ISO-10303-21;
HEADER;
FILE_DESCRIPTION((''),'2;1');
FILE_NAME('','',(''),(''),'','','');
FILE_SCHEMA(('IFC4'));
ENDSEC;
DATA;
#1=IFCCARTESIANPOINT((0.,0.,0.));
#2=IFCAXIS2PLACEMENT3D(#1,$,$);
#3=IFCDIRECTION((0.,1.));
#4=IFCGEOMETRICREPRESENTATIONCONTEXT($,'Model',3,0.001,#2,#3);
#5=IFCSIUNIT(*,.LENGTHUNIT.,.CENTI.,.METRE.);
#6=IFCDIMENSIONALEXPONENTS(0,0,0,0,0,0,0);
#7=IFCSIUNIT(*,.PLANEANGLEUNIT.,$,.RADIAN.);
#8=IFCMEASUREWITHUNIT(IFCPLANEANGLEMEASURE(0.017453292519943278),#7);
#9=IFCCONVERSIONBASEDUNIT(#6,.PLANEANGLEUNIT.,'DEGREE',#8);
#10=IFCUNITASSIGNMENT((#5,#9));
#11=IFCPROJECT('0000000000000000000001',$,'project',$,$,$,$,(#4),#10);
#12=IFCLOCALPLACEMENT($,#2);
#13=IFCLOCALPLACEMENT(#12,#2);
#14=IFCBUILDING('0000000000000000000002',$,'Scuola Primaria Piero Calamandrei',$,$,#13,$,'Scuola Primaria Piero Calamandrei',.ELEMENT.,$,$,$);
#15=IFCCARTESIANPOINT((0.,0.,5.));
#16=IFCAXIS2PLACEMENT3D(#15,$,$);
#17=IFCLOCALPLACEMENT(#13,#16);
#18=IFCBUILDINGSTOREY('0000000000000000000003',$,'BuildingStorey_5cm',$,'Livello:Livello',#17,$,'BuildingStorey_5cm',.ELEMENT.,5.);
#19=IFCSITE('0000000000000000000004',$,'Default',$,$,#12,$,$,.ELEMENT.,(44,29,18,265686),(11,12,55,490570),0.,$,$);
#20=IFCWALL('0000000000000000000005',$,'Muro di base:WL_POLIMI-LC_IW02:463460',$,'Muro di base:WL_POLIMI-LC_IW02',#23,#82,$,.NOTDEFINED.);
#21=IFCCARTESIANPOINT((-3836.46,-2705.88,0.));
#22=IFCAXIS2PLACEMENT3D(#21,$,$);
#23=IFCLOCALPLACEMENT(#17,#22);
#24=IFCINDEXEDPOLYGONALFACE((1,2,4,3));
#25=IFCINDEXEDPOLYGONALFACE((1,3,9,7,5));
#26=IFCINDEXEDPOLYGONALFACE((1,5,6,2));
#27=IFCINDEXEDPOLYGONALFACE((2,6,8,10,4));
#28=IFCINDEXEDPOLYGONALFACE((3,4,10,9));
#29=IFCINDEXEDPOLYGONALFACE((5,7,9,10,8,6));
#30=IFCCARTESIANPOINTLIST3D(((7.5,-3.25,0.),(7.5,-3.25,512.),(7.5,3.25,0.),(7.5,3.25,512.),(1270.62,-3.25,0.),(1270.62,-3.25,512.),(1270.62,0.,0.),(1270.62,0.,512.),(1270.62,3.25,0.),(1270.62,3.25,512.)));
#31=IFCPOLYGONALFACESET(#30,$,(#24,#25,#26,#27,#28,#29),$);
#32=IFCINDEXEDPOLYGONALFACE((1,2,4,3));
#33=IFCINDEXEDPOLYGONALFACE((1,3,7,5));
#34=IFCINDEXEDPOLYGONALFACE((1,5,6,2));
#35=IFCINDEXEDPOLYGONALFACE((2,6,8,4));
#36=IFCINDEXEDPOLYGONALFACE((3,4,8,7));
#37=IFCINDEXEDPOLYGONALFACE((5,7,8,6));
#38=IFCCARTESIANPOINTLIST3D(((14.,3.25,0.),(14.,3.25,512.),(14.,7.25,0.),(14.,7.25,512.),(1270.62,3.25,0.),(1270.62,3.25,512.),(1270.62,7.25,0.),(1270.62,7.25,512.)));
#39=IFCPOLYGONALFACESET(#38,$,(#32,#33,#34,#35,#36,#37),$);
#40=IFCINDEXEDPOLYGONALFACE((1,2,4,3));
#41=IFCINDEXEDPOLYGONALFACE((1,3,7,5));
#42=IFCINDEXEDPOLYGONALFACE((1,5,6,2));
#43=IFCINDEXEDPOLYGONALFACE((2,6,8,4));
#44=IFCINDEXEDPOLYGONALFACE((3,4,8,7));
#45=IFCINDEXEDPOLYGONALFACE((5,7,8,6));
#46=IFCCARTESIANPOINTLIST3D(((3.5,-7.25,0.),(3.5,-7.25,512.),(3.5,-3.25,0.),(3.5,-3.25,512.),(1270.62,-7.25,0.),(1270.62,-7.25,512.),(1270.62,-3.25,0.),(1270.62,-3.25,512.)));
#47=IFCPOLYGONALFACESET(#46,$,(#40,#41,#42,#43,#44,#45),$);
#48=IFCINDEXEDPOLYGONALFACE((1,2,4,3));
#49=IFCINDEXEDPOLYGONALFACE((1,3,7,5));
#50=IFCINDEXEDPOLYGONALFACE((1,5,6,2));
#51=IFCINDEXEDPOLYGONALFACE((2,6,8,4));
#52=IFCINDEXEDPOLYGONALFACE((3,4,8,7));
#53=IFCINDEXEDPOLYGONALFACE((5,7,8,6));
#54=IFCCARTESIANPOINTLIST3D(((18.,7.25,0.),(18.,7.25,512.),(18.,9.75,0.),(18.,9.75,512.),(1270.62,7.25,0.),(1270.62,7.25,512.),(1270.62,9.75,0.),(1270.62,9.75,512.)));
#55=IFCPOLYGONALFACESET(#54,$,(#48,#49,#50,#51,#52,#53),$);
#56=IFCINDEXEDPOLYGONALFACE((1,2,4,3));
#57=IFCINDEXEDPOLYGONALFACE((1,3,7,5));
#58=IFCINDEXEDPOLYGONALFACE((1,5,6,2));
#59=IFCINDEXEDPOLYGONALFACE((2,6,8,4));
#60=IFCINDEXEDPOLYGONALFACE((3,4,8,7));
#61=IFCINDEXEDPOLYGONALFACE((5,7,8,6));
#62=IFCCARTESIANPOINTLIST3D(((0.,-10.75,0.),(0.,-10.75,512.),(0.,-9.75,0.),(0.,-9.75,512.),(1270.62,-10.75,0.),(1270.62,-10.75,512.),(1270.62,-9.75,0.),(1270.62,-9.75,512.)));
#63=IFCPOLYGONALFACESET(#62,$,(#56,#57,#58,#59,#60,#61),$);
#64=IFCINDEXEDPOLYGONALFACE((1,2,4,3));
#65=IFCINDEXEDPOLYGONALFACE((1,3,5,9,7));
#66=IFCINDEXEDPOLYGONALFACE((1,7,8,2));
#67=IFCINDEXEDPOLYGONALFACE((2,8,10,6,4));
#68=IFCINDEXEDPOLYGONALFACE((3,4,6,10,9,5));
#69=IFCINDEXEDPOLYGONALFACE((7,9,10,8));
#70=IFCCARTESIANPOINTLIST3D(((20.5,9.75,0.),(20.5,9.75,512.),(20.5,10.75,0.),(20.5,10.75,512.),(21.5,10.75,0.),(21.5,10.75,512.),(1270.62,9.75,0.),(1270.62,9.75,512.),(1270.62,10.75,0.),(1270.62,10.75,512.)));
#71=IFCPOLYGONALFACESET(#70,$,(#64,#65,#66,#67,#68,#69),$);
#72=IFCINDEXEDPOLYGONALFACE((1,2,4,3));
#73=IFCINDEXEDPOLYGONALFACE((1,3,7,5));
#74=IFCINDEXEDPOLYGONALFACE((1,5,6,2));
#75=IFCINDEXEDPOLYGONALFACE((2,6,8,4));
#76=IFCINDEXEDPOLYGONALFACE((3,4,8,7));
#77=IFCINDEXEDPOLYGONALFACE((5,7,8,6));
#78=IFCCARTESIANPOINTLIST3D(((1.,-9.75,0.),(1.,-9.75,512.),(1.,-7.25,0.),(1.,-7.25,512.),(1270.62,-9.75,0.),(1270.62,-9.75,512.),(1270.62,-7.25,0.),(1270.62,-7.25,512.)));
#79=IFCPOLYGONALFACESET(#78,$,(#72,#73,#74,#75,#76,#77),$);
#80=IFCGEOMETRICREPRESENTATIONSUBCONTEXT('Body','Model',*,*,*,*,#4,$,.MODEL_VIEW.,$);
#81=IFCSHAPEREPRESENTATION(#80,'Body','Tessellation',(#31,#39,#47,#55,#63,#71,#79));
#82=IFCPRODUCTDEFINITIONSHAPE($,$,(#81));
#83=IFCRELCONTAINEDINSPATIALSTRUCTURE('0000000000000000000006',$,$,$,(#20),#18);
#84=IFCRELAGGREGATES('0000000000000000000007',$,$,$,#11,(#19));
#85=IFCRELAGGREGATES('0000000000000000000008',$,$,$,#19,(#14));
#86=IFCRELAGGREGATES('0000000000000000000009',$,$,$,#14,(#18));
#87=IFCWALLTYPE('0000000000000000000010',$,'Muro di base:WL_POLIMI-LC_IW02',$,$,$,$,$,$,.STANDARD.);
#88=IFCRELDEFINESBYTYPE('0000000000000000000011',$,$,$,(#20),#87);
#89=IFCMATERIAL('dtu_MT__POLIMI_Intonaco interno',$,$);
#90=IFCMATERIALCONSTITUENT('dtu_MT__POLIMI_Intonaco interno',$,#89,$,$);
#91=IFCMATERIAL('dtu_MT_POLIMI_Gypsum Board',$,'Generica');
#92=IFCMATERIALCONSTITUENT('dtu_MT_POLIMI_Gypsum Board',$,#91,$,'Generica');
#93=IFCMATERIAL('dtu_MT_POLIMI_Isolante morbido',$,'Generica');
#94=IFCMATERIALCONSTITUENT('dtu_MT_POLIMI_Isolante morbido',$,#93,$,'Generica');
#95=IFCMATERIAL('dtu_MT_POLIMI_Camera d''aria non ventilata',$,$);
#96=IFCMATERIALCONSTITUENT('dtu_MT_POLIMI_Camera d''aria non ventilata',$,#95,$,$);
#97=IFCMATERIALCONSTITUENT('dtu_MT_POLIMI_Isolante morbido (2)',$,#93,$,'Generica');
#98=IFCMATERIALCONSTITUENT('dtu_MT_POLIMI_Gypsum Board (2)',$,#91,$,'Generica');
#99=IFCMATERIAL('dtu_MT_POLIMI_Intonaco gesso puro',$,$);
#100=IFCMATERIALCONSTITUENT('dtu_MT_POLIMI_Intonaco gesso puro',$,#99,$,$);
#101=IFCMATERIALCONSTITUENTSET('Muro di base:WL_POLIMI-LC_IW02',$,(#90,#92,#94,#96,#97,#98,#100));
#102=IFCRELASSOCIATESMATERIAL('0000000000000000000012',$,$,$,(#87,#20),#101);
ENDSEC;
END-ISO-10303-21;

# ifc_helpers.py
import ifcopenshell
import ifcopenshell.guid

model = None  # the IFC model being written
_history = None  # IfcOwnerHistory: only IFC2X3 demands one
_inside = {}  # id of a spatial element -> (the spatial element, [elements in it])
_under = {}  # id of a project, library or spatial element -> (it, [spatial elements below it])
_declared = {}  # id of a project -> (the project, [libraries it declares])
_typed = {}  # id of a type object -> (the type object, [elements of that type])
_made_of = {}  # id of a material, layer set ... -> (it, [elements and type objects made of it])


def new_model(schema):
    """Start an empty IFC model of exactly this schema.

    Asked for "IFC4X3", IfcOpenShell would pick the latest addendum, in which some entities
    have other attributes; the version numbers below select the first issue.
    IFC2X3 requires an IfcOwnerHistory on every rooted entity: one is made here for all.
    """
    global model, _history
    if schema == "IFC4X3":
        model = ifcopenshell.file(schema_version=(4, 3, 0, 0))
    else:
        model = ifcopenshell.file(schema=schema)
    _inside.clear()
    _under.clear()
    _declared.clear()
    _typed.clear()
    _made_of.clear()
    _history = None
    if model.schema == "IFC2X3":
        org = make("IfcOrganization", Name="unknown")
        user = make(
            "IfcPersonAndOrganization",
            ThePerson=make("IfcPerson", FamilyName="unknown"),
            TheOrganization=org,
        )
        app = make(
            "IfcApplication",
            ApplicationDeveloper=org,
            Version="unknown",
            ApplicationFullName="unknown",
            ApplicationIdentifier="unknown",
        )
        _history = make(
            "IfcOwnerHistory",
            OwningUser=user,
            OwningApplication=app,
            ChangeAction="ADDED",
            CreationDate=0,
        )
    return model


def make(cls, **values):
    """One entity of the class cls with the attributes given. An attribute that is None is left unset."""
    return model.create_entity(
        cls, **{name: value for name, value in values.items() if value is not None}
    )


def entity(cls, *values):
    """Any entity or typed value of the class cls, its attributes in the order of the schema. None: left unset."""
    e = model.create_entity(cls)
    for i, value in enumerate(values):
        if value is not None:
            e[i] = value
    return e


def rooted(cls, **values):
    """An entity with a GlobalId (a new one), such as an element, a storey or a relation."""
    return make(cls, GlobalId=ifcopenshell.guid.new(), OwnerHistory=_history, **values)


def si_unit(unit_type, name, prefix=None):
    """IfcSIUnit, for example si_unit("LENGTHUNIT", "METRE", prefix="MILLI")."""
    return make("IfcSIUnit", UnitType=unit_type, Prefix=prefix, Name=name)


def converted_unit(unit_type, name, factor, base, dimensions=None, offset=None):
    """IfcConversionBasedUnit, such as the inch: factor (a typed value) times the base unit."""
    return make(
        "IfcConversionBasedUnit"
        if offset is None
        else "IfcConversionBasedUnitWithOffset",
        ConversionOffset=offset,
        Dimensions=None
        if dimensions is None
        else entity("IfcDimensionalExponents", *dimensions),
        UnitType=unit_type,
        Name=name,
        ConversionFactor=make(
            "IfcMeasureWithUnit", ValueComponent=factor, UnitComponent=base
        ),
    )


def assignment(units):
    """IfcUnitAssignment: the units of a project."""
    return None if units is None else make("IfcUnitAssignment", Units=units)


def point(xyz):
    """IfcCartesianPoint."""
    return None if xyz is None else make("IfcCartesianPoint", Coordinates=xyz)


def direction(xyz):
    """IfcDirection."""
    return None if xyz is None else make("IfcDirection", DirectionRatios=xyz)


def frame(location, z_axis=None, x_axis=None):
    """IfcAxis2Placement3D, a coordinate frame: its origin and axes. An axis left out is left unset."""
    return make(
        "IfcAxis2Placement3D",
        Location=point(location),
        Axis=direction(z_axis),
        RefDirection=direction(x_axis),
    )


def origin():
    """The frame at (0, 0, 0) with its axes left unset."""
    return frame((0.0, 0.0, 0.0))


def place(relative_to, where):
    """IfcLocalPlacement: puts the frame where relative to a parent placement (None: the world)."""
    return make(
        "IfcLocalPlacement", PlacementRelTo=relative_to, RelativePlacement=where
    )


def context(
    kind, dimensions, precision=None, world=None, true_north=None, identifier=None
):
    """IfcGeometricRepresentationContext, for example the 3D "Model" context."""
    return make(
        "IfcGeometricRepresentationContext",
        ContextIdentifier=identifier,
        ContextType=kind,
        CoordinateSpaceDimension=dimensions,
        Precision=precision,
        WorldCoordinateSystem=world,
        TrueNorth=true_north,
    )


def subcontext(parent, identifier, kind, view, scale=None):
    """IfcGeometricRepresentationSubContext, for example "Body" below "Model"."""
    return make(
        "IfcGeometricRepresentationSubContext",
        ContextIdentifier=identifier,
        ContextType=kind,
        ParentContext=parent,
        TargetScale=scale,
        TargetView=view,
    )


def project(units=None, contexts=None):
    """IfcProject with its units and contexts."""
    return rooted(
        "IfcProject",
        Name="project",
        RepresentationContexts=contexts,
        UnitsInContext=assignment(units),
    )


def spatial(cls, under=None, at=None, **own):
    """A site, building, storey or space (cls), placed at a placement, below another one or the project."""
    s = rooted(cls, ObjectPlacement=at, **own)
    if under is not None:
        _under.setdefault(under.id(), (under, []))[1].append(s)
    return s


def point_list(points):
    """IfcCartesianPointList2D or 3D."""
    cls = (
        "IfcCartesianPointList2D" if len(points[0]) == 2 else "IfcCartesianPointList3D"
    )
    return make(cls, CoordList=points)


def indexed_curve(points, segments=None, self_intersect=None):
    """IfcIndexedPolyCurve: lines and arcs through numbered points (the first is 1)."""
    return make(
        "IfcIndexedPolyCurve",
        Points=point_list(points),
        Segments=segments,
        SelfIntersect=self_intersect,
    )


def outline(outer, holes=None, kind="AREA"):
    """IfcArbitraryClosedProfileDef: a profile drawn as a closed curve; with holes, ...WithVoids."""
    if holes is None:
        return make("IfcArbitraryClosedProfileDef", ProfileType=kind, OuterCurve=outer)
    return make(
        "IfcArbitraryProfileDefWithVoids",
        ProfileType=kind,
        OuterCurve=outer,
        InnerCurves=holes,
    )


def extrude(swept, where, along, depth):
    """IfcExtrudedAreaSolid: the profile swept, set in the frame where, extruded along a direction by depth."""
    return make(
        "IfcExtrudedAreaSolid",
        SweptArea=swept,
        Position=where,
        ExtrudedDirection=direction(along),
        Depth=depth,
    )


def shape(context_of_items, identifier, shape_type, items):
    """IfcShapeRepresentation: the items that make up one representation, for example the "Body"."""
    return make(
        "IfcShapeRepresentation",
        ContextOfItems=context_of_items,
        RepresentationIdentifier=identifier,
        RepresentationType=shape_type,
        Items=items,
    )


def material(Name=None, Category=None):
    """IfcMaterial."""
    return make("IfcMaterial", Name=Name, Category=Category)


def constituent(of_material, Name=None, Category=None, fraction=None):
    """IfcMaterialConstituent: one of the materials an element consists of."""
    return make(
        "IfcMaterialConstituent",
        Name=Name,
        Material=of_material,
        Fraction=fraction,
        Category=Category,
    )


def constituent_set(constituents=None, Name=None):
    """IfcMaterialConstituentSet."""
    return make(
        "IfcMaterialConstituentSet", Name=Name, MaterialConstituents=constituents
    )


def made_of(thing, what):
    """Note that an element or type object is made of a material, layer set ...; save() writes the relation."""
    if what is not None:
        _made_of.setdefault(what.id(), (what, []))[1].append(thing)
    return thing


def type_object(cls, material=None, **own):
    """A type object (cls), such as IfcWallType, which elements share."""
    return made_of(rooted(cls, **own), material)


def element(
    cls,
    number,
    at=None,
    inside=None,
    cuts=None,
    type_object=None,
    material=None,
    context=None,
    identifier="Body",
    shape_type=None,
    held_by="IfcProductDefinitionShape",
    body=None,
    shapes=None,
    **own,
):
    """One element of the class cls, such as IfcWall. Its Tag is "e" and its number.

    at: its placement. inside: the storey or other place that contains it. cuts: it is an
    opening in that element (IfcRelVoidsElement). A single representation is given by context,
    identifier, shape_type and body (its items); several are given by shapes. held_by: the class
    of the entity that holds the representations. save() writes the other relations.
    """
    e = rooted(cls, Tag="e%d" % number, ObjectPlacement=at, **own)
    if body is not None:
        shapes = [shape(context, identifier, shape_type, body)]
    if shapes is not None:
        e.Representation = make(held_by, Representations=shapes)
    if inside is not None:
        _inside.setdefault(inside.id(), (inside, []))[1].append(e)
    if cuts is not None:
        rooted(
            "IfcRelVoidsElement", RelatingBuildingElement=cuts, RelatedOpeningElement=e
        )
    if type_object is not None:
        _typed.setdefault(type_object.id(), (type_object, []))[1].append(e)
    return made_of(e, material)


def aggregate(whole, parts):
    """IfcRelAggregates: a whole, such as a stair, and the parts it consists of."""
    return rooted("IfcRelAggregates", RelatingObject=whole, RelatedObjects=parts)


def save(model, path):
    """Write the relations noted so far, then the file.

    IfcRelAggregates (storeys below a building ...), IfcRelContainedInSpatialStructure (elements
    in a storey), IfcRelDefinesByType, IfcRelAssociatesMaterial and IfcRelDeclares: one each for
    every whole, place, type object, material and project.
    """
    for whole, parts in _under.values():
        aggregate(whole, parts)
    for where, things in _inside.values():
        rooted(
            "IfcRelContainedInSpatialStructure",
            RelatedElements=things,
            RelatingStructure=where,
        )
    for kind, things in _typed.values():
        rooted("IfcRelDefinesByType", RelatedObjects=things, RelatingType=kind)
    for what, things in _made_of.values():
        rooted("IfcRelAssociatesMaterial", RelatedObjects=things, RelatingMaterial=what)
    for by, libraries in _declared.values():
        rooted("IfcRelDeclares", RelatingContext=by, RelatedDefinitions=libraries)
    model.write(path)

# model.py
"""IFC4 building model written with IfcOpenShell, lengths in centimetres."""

from ifc_helpers import new_model, entity, si_unit, converted_unit, direction, frame, origin, place, context, subcontext, project, spatial, indexed_curve, outline, extrude, material, constituent, constituent_set, type_object, element, save


model = new_model("IFC4")

# Units and contexts
model_context = context("Model", 3, precision=0.001, world=origin(), true_north=direction((0.0, 1.0)))
body_context = subcontext(model_context, "Body", "Model", "MODEL_VIEW")
ifc_project = project(units=[si_unit("LENGTHUNIT", "METRE", prefix="CENTI"), converted_unit("PLANEANGLEUNIT", "DEGREE", entity("IfcPlaneAngleMeasure", 0.017453292519943278), si_unit("PLANEANGLEUNIT", "RADIAN"), dimensions=[0, 0, 0, 0, 0, 0, 0])], contexts=[model_context])

# Site, building, storey
site_placement = place(None, origin())
site = spatial("IfcSite", under=ifc_project, at=site_placement, Name="Default", CompositionType="ELEMENT", RefLatitude=(44, 29, 18, 265686), RefLongitude=(11, 12, 55, 490570), RefElevation=0.0)
building_placement = place(site_placement, origin())
building = spatial("IfcBuilding", under=site, at=building_placement, Name="Scuola Primaria Piero Calamandrei", LongName="Scuola Primaria Piero Calamandrei", CompositionType="ELEMENT")
storey_placement = place(building_placement, frame((0.0, 0.0, 5.0)))
storey = spatial("IfcBuildingStorey", under=building, at=storey_placement, Name="BuildingStorey_5cm", ObjectType="Livello:Livello", LongName="BuildingStorey_5cm", CompositionType="ELEMENT", Elevation=5.0)

# Shared definitions
ifc_material_1 = material(Name="dtu_MT_POLIMI_Intonaco gesso puro")

# Wall
ifc_material_2 = material(Name="dtu_MT_POLIMI_Isolante morbido", Category="Generica")
ifc_material_3 = material(Name="dtu_MT_POLIMI_Gypsum Board", Category="Generica")
ifc_material_4 = material(Name="dtu_MT__POLIMI_Intonaco interno")
ifc_constituent_1 = constituent(ifc_material_4, Name="dtu_MT__POLIMI_Intonaco interno")
ifc_constituent_2 = constituent(ifc_material_3, Name="dtu_MT_POLIMI_Gypsum Board", Category="Generica")
ifc_constituent_3 = constituent(ifc_material_2, Name="dtu_MT_POLIMI_Isolante morbido", Category="Generica")
ifc_material_5 = material(Name="dtu_MT_POLIMI_Camera d'aria non ventilata")
ifc_constituent_4 = constituent(ifc_material_5, Name="dtu_MT_POLIMI_Camera d'aria non ventilata")
ifc_constituent_5 = constituent(ifc_material_2, Name="dtu_MT_POLIMI_Isolante morbido (2)", Category="Generica")
ifc_constituent_6 = constituent(ifc_material_3, Name="dtu_MT_POLIMI_Gypsum Board (2)", Category="Generica")
ifc_constituent_7 = constituent(ifc_material_1, Name="dtu_MT_POLIMI_Intonaco gesso puro")
ifc_constituent_set_1 = constituent_set(constituents=[ifc_constituent_1, ifc_constituent_2, ifc_constituent_3, ifc_constituent_4, ifc_constituent_5, ifc_constituent_6, ifc_constituent_7], Name="Muro di base:WL_POLIMI-LC_IW02")
wall_type_1 = type_object("IfcWallType", Name="Muro di base:WL_POLIMI-LC_IW02", PredefinedType="STANDARD", material=ifc_constituent_set_1)
wall_1_placement = place(storey_placement, frame((-3836.46, -2705.88, 0.0)))
element("IfcWall", 1, at=wall_1_placement, inside=storey, type_object=wall_type_1, material=ifc_constituent_set_1, Name="Muro di base:WL_POLIMI-LC_IW02:463460", ObjectType="Muro di base:WL_POLIMI-LC_IW02", PredefinedType="NOTDEFINED", context=body_context, shape_type="SweptSolid", body=[
    extrude(outline(indexed_curve([(-757.87, -3.25), (505.25, -3.25), (505.25, 0.0), (505.25, 3.25), (-757.87, 3.25), (-757.87, -3.25)], self_intersect=False)), frame((765.37, 0.0, 0.0)), (0.0, 0.0, 1.0), 512.0),
    extrude(outline(indexed_curve([(-628.31, -2.0), (628.31, -2.0), (628.31, 2.0), (-628.31, 2.0), (-628.31, -2.0)], self_intersect=False)), frame((642.31, 5.25, 0.0)), (0.0, 0.0, 1.0), 512.0),
    extrude(outline(indexed_curve([(-633.56, -2.0), (633.56, -2.0), (633.56, 2.0), (-633.56, 2.0), (-633.56, -2.0)], self_intersect=False)), frame((637.06, -5.25, 0.0)), (0.0, 0.0, 1.0), 512.0),
    extrude(outline(indexed_curve([(-626.31, -1.25), (626.31, -1.25), (626.31, 1.25), (-626.31, 1.25), (-626.31, -1.25)], self_intersect=False)), frame((644.31, 8.5, 0.0)), (0.0, 0.0, 1.0), 512.0),
    extrude(outline(indexed_curve([(-0.5, -635.31), (0.5, -635.31), (0.5, 635.31), (-0.5, 635.31), (-0.5, -635.31)], self_intersect=False)), frame((635.31, -10.25, 0.0), z_axis=(0.0, 0.0, 1.0), x_axis=(0.0, 1.0, 0.0)), (0.0, 0.0, 1.0), 512.0),
    extrude(outline(indexed_curve([(499.25, -0.4), (500.25, -0.4), (500.25, 0.6), (-749.87, 0.6), (-749.87, -0.4), (499.25, -0.4)], self_intersect=False)), frame((520.75, 10.35, 0.0), z_axis=(0.0, 0.0, 1.0), x_axis=(-1.0, 0.0, 0.0)), (0.0, 0.0, 1.0), 512.0),
    extrude(outline(indexed_curve([(-634.81, -1.25), (634.81, -1.25), (634.81, 1.25), (-634.81, 1.25), (-634.81, -1.25)], self_intersect=False)), frame((635.81, -8.5, 0.0)), (0.0, 0.0, 1.0), 512.0),
])

save(model, "model.ifc")
